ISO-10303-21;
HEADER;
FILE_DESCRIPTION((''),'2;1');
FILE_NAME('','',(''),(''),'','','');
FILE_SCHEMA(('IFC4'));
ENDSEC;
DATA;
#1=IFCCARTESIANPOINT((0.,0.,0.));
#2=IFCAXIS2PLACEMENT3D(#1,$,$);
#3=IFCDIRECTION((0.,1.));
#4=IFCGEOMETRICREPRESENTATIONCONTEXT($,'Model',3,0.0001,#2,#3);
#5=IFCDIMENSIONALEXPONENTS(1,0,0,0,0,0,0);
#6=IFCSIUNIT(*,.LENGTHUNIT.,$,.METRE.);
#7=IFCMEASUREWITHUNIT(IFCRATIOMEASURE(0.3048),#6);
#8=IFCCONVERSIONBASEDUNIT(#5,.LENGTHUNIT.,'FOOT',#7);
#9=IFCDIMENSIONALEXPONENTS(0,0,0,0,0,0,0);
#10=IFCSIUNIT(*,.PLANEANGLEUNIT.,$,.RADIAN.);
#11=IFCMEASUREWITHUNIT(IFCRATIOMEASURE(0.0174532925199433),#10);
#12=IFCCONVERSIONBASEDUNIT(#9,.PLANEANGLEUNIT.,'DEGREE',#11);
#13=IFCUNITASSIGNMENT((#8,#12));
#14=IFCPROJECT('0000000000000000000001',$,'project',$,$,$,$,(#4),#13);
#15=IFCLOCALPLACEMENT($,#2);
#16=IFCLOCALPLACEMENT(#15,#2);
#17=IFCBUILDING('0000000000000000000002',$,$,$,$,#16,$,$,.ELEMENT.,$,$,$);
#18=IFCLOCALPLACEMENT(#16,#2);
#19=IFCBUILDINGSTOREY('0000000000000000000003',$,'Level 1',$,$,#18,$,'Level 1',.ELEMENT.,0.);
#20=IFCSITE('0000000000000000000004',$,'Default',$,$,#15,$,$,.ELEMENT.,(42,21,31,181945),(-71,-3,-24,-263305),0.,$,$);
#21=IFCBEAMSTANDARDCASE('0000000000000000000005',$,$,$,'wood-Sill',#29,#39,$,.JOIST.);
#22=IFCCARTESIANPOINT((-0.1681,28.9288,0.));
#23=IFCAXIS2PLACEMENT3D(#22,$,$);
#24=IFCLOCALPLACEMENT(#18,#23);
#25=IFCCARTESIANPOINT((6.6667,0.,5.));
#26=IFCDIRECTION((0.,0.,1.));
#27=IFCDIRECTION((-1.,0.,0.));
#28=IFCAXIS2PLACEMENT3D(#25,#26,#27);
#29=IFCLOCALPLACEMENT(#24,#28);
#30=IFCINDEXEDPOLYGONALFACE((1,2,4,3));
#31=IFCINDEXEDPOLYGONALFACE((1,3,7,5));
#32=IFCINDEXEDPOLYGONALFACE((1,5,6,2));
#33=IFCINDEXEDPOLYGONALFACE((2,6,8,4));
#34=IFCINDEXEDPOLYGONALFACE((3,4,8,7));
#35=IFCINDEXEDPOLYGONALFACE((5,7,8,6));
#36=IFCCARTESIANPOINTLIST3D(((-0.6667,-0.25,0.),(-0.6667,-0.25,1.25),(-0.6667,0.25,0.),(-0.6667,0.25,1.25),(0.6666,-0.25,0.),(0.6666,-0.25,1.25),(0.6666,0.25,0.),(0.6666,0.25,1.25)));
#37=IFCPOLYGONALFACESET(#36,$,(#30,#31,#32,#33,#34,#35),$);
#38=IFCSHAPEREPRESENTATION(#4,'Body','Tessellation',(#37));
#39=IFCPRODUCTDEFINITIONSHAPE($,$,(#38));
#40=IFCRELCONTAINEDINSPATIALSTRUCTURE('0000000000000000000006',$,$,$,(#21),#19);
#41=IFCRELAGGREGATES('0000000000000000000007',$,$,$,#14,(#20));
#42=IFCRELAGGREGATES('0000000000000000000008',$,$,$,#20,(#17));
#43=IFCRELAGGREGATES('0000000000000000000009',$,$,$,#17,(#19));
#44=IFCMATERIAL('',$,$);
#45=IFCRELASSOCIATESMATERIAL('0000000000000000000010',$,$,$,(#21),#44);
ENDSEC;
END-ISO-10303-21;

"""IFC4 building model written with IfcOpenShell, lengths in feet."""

from ifc_helpers import new_model, entity, si_unit, converted_unit, direction, frame, origin, place, context, project, spatial, rectangle, extrude, material, element, save


model = new_model("IFC4")

# Units and contexts
model_context = context("Model", 3, precision=0.0001, world=origin(), true_north=direction((0.0, 1.0)))
ifc_project = project(units=[converted_unit("LENGTHUNIT", "FOOT", entity("IfcRatioMeasure", 0.3048), si_unit("LENGTHUNIT", "METRE"), dimensions=[1, 0, 0, 0, 0, 0, 0]), converted_unit("PLANEANGLEUNIT", "DEGREE", entity("IfcRatioMeasure", 0.0174532925199433), si_unit("PLANEANGLEUNIT", "RADIAN"), dimensions=[0, 0, 0, 0, 0, 0, 0])], contexts=[model_context])

# Site, building, storey
site_placement = place(None, origin())
site = spatial("IfcSite", under=ifc_project, at=site_placement, Name="Default", CompositionType="ELEMENT", RefLatitude=(42, 21, 31, 181945), RefLongitude=(-71, -3, -24, -263305), RefElevation=0.0)
building_placement = place(site_placement, origin())
building = spatial("IfcBuilding", under=site, at=building_placement, CompositionType="ELEMENT")
storey_placement = place(building_placement, origin())
storey = spatial("IfcBuildingStorey", under=building, at=storey_placement, Name="Level 1", LongName="Level 1", CompositionType="ELEMENT", Elevation=0.0)

# Shared definitions
placement_1 = place(storey_placement, frame((-0.1681, 28.9288, 0.0)))

# Beam
ifc_material_1 = material(Name="")
for number, where, z_axis, x_axis in (
    (1, (6.6667, 0.0, 5.0), (0.0, 0.0, 1.0), (-1.0, 0.0, 0.0)),
):
    element("IfcBeamStandardCase", number, at=place(placement_1, frame(where, z_axis=z_axis, x_axis=x_axis)), inside=storey, material=ifc_material_1, ObjectType="wood-Sill", PredefinedType="JOIST", context=model_context, shape_type="SweptSolid", body=[
        extrude(rectangle(XDim=1.3333, YDim=0.5), origin(), (0.0, 0.0, 1.0), 1.25),
    ])

save(model, "model.ifc")
